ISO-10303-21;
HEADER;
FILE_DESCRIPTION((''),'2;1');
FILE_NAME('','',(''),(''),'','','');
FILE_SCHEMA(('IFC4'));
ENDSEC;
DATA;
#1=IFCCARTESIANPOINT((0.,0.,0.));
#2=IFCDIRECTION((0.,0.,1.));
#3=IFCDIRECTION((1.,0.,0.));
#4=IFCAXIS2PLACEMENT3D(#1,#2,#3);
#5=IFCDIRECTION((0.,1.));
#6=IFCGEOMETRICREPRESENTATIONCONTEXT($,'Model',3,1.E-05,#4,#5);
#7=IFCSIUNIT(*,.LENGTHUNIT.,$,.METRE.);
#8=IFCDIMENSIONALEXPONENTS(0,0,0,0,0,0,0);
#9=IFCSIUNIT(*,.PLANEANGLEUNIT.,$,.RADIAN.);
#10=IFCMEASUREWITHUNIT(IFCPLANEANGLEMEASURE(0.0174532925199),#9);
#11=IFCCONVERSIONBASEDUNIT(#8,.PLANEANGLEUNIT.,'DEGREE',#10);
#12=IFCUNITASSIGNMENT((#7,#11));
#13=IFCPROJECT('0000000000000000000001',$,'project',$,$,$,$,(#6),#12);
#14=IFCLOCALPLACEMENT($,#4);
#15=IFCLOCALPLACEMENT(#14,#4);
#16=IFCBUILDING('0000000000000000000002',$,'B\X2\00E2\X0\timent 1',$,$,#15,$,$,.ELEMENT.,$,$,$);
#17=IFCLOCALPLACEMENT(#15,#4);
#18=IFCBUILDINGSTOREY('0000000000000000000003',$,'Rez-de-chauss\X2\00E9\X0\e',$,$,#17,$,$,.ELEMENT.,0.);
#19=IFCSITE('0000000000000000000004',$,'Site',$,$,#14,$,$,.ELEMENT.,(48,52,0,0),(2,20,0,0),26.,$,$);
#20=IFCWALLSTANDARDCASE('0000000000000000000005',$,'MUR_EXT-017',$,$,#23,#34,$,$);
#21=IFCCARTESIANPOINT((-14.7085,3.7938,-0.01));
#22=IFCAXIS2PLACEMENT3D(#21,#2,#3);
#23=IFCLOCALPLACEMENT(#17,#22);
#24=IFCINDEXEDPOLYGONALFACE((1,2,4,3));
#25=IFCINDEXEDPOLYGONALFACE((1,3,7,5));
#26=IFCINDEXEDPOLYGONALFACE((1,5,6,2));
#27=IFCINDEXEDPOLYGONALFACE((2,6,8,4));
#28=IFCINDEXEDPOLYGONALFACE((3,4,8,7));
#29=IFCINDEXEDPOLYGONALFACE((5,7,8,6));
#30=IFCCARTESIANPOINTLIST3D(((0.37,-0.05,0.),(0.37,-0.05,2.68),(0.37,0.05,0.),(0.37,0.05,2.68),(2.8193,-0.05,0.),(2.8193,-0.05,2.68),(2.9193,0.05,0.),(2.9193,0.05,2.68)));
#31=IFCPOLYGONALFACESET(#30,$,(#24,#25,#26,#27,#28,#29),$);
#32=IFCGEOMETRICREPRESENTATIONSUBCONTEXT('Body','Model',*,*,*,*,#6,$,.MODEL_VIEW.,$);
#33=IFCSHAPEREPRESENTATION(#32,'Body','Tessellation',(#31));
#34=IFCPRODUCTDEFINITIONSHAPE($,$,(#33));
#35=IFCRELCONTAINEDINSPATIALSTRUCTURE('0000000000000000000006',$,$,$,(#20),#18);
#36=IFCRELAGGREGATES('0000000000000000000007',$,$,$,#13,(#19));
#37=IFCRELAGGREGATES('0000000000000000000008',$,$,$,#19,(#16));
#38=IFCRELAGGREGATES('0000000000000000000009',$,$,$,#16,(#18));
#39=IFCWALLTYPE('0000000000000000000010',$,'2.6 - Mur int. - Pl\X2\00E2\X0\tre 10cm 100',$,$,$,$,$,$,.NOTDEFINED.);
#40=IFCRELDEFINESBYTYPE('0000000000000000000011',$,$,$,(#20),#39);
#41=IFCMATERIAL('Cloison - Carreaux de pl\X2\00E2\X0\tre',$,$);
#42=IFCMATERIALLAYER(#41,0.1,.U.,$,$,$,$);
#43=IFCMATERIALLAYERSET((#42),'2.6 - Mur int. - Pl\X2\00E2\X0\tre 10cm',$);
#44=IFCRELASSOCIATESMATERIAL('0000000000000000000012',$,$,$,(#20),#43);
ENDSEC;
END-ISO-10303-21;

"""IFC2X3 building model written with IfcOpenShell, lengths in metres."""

from ifc_helpers import new_model, entity, si_unit, converted_unit, direction, frame, origin_with_axes, place, context, subcontext, project, spatial, polyline, outline, extrude, material, layer, layer_set, layer_usage, type_object, element, save


model = new_model("IFC2X3")

# Units and contexts
model_context = context("Model", 3, precision=1e-05, world=origin_with_axes(), true_north=direction((0.0, 1.0)))
body_context = subcontext(model_context, "Body", "Model", "MODEL_VIEW")
ifc_project = project(units=[si_unit("LENGTHUNIT", "METRE"), converted_unit("PLANEANGLEUNIT", "DEGREE", entity("IfcPlaneAngleMeasure", 0.0174532925199), si_unit("PLANEANGLEUNIT", "RADIAN"), dimensions=[0, 0, 0, 0, 0, 0, 0])], contexts=[model_context])

# Site, building, storey
site_placement = place(None, origin_with_axes())
site = spatial("IfcSite", under=ifc_project, at=site_placement, Name="Site", CompositionType="ELEMENT", RefLatitude=(48, 52, 0, 0), RefLongitude=(2, 20, 0, 0), RefElevation=26.0)
building_placement = place(site_placement, origin_with_axes())
building = spatial("IfcBuilding", under=site, at=building_placement, Name="Bâtiment 1", CompositionType="ELEMENT")
storey_placement = place(building_placement, origin_with_axes())
storey = spatial("IfcBuildingStorey", under=building, at=storey_placement, Name="Rez-de-chaussée", CompositionType="ELEMENT", Elevation=0.0)

# Shared definitions
ifc_material_1 = material(Name="Cloison - Carreaux de plâtre")
ifc_layer_1 = layer(ifc_material_1, 0.1, ventilated="UNKNOWN")
ifc_layer_set_1 = layer_set([ifc_layer_1], Name="2.6 - Mur int. - Plâtre 10cm")
wall_type_1 = type_object("IfcWallType", Name="2.6 - Mur int. - Plâtre 10cm 100", PredefinedType="NOTDEFINED")

# Wall
ifc_layer_usage_1 = layer_usage(ifc_layer_set_1, "AXIS2", "POSITIVE", -0.05)
wall_1_placement = place(storey_placement, frame((-14.7085, 3.7938, -0.01), z_axis=(0.0, 0.0, 1.0), x_axis=(1.0, 0.0, 0.0)))
element("IfcWallStandardCase", 1, at=wall_1_placement, inside=storey, type_object=wall_type_1, material=ifc_layer_usage_1, Name="MUR_EXT-017", context=body_context, shape_type="SweptSolid", body=[
    extrude(outline(polyline([(0.37, -0.05), (2.8193, -0.05), (2.9193, 0.05), (0.37, 0.05), (0.37, -0.05)])), origin_with_axes(), (0.0, 0.0, 1.0), 2.68),
])

save(model, "model.ifc")
